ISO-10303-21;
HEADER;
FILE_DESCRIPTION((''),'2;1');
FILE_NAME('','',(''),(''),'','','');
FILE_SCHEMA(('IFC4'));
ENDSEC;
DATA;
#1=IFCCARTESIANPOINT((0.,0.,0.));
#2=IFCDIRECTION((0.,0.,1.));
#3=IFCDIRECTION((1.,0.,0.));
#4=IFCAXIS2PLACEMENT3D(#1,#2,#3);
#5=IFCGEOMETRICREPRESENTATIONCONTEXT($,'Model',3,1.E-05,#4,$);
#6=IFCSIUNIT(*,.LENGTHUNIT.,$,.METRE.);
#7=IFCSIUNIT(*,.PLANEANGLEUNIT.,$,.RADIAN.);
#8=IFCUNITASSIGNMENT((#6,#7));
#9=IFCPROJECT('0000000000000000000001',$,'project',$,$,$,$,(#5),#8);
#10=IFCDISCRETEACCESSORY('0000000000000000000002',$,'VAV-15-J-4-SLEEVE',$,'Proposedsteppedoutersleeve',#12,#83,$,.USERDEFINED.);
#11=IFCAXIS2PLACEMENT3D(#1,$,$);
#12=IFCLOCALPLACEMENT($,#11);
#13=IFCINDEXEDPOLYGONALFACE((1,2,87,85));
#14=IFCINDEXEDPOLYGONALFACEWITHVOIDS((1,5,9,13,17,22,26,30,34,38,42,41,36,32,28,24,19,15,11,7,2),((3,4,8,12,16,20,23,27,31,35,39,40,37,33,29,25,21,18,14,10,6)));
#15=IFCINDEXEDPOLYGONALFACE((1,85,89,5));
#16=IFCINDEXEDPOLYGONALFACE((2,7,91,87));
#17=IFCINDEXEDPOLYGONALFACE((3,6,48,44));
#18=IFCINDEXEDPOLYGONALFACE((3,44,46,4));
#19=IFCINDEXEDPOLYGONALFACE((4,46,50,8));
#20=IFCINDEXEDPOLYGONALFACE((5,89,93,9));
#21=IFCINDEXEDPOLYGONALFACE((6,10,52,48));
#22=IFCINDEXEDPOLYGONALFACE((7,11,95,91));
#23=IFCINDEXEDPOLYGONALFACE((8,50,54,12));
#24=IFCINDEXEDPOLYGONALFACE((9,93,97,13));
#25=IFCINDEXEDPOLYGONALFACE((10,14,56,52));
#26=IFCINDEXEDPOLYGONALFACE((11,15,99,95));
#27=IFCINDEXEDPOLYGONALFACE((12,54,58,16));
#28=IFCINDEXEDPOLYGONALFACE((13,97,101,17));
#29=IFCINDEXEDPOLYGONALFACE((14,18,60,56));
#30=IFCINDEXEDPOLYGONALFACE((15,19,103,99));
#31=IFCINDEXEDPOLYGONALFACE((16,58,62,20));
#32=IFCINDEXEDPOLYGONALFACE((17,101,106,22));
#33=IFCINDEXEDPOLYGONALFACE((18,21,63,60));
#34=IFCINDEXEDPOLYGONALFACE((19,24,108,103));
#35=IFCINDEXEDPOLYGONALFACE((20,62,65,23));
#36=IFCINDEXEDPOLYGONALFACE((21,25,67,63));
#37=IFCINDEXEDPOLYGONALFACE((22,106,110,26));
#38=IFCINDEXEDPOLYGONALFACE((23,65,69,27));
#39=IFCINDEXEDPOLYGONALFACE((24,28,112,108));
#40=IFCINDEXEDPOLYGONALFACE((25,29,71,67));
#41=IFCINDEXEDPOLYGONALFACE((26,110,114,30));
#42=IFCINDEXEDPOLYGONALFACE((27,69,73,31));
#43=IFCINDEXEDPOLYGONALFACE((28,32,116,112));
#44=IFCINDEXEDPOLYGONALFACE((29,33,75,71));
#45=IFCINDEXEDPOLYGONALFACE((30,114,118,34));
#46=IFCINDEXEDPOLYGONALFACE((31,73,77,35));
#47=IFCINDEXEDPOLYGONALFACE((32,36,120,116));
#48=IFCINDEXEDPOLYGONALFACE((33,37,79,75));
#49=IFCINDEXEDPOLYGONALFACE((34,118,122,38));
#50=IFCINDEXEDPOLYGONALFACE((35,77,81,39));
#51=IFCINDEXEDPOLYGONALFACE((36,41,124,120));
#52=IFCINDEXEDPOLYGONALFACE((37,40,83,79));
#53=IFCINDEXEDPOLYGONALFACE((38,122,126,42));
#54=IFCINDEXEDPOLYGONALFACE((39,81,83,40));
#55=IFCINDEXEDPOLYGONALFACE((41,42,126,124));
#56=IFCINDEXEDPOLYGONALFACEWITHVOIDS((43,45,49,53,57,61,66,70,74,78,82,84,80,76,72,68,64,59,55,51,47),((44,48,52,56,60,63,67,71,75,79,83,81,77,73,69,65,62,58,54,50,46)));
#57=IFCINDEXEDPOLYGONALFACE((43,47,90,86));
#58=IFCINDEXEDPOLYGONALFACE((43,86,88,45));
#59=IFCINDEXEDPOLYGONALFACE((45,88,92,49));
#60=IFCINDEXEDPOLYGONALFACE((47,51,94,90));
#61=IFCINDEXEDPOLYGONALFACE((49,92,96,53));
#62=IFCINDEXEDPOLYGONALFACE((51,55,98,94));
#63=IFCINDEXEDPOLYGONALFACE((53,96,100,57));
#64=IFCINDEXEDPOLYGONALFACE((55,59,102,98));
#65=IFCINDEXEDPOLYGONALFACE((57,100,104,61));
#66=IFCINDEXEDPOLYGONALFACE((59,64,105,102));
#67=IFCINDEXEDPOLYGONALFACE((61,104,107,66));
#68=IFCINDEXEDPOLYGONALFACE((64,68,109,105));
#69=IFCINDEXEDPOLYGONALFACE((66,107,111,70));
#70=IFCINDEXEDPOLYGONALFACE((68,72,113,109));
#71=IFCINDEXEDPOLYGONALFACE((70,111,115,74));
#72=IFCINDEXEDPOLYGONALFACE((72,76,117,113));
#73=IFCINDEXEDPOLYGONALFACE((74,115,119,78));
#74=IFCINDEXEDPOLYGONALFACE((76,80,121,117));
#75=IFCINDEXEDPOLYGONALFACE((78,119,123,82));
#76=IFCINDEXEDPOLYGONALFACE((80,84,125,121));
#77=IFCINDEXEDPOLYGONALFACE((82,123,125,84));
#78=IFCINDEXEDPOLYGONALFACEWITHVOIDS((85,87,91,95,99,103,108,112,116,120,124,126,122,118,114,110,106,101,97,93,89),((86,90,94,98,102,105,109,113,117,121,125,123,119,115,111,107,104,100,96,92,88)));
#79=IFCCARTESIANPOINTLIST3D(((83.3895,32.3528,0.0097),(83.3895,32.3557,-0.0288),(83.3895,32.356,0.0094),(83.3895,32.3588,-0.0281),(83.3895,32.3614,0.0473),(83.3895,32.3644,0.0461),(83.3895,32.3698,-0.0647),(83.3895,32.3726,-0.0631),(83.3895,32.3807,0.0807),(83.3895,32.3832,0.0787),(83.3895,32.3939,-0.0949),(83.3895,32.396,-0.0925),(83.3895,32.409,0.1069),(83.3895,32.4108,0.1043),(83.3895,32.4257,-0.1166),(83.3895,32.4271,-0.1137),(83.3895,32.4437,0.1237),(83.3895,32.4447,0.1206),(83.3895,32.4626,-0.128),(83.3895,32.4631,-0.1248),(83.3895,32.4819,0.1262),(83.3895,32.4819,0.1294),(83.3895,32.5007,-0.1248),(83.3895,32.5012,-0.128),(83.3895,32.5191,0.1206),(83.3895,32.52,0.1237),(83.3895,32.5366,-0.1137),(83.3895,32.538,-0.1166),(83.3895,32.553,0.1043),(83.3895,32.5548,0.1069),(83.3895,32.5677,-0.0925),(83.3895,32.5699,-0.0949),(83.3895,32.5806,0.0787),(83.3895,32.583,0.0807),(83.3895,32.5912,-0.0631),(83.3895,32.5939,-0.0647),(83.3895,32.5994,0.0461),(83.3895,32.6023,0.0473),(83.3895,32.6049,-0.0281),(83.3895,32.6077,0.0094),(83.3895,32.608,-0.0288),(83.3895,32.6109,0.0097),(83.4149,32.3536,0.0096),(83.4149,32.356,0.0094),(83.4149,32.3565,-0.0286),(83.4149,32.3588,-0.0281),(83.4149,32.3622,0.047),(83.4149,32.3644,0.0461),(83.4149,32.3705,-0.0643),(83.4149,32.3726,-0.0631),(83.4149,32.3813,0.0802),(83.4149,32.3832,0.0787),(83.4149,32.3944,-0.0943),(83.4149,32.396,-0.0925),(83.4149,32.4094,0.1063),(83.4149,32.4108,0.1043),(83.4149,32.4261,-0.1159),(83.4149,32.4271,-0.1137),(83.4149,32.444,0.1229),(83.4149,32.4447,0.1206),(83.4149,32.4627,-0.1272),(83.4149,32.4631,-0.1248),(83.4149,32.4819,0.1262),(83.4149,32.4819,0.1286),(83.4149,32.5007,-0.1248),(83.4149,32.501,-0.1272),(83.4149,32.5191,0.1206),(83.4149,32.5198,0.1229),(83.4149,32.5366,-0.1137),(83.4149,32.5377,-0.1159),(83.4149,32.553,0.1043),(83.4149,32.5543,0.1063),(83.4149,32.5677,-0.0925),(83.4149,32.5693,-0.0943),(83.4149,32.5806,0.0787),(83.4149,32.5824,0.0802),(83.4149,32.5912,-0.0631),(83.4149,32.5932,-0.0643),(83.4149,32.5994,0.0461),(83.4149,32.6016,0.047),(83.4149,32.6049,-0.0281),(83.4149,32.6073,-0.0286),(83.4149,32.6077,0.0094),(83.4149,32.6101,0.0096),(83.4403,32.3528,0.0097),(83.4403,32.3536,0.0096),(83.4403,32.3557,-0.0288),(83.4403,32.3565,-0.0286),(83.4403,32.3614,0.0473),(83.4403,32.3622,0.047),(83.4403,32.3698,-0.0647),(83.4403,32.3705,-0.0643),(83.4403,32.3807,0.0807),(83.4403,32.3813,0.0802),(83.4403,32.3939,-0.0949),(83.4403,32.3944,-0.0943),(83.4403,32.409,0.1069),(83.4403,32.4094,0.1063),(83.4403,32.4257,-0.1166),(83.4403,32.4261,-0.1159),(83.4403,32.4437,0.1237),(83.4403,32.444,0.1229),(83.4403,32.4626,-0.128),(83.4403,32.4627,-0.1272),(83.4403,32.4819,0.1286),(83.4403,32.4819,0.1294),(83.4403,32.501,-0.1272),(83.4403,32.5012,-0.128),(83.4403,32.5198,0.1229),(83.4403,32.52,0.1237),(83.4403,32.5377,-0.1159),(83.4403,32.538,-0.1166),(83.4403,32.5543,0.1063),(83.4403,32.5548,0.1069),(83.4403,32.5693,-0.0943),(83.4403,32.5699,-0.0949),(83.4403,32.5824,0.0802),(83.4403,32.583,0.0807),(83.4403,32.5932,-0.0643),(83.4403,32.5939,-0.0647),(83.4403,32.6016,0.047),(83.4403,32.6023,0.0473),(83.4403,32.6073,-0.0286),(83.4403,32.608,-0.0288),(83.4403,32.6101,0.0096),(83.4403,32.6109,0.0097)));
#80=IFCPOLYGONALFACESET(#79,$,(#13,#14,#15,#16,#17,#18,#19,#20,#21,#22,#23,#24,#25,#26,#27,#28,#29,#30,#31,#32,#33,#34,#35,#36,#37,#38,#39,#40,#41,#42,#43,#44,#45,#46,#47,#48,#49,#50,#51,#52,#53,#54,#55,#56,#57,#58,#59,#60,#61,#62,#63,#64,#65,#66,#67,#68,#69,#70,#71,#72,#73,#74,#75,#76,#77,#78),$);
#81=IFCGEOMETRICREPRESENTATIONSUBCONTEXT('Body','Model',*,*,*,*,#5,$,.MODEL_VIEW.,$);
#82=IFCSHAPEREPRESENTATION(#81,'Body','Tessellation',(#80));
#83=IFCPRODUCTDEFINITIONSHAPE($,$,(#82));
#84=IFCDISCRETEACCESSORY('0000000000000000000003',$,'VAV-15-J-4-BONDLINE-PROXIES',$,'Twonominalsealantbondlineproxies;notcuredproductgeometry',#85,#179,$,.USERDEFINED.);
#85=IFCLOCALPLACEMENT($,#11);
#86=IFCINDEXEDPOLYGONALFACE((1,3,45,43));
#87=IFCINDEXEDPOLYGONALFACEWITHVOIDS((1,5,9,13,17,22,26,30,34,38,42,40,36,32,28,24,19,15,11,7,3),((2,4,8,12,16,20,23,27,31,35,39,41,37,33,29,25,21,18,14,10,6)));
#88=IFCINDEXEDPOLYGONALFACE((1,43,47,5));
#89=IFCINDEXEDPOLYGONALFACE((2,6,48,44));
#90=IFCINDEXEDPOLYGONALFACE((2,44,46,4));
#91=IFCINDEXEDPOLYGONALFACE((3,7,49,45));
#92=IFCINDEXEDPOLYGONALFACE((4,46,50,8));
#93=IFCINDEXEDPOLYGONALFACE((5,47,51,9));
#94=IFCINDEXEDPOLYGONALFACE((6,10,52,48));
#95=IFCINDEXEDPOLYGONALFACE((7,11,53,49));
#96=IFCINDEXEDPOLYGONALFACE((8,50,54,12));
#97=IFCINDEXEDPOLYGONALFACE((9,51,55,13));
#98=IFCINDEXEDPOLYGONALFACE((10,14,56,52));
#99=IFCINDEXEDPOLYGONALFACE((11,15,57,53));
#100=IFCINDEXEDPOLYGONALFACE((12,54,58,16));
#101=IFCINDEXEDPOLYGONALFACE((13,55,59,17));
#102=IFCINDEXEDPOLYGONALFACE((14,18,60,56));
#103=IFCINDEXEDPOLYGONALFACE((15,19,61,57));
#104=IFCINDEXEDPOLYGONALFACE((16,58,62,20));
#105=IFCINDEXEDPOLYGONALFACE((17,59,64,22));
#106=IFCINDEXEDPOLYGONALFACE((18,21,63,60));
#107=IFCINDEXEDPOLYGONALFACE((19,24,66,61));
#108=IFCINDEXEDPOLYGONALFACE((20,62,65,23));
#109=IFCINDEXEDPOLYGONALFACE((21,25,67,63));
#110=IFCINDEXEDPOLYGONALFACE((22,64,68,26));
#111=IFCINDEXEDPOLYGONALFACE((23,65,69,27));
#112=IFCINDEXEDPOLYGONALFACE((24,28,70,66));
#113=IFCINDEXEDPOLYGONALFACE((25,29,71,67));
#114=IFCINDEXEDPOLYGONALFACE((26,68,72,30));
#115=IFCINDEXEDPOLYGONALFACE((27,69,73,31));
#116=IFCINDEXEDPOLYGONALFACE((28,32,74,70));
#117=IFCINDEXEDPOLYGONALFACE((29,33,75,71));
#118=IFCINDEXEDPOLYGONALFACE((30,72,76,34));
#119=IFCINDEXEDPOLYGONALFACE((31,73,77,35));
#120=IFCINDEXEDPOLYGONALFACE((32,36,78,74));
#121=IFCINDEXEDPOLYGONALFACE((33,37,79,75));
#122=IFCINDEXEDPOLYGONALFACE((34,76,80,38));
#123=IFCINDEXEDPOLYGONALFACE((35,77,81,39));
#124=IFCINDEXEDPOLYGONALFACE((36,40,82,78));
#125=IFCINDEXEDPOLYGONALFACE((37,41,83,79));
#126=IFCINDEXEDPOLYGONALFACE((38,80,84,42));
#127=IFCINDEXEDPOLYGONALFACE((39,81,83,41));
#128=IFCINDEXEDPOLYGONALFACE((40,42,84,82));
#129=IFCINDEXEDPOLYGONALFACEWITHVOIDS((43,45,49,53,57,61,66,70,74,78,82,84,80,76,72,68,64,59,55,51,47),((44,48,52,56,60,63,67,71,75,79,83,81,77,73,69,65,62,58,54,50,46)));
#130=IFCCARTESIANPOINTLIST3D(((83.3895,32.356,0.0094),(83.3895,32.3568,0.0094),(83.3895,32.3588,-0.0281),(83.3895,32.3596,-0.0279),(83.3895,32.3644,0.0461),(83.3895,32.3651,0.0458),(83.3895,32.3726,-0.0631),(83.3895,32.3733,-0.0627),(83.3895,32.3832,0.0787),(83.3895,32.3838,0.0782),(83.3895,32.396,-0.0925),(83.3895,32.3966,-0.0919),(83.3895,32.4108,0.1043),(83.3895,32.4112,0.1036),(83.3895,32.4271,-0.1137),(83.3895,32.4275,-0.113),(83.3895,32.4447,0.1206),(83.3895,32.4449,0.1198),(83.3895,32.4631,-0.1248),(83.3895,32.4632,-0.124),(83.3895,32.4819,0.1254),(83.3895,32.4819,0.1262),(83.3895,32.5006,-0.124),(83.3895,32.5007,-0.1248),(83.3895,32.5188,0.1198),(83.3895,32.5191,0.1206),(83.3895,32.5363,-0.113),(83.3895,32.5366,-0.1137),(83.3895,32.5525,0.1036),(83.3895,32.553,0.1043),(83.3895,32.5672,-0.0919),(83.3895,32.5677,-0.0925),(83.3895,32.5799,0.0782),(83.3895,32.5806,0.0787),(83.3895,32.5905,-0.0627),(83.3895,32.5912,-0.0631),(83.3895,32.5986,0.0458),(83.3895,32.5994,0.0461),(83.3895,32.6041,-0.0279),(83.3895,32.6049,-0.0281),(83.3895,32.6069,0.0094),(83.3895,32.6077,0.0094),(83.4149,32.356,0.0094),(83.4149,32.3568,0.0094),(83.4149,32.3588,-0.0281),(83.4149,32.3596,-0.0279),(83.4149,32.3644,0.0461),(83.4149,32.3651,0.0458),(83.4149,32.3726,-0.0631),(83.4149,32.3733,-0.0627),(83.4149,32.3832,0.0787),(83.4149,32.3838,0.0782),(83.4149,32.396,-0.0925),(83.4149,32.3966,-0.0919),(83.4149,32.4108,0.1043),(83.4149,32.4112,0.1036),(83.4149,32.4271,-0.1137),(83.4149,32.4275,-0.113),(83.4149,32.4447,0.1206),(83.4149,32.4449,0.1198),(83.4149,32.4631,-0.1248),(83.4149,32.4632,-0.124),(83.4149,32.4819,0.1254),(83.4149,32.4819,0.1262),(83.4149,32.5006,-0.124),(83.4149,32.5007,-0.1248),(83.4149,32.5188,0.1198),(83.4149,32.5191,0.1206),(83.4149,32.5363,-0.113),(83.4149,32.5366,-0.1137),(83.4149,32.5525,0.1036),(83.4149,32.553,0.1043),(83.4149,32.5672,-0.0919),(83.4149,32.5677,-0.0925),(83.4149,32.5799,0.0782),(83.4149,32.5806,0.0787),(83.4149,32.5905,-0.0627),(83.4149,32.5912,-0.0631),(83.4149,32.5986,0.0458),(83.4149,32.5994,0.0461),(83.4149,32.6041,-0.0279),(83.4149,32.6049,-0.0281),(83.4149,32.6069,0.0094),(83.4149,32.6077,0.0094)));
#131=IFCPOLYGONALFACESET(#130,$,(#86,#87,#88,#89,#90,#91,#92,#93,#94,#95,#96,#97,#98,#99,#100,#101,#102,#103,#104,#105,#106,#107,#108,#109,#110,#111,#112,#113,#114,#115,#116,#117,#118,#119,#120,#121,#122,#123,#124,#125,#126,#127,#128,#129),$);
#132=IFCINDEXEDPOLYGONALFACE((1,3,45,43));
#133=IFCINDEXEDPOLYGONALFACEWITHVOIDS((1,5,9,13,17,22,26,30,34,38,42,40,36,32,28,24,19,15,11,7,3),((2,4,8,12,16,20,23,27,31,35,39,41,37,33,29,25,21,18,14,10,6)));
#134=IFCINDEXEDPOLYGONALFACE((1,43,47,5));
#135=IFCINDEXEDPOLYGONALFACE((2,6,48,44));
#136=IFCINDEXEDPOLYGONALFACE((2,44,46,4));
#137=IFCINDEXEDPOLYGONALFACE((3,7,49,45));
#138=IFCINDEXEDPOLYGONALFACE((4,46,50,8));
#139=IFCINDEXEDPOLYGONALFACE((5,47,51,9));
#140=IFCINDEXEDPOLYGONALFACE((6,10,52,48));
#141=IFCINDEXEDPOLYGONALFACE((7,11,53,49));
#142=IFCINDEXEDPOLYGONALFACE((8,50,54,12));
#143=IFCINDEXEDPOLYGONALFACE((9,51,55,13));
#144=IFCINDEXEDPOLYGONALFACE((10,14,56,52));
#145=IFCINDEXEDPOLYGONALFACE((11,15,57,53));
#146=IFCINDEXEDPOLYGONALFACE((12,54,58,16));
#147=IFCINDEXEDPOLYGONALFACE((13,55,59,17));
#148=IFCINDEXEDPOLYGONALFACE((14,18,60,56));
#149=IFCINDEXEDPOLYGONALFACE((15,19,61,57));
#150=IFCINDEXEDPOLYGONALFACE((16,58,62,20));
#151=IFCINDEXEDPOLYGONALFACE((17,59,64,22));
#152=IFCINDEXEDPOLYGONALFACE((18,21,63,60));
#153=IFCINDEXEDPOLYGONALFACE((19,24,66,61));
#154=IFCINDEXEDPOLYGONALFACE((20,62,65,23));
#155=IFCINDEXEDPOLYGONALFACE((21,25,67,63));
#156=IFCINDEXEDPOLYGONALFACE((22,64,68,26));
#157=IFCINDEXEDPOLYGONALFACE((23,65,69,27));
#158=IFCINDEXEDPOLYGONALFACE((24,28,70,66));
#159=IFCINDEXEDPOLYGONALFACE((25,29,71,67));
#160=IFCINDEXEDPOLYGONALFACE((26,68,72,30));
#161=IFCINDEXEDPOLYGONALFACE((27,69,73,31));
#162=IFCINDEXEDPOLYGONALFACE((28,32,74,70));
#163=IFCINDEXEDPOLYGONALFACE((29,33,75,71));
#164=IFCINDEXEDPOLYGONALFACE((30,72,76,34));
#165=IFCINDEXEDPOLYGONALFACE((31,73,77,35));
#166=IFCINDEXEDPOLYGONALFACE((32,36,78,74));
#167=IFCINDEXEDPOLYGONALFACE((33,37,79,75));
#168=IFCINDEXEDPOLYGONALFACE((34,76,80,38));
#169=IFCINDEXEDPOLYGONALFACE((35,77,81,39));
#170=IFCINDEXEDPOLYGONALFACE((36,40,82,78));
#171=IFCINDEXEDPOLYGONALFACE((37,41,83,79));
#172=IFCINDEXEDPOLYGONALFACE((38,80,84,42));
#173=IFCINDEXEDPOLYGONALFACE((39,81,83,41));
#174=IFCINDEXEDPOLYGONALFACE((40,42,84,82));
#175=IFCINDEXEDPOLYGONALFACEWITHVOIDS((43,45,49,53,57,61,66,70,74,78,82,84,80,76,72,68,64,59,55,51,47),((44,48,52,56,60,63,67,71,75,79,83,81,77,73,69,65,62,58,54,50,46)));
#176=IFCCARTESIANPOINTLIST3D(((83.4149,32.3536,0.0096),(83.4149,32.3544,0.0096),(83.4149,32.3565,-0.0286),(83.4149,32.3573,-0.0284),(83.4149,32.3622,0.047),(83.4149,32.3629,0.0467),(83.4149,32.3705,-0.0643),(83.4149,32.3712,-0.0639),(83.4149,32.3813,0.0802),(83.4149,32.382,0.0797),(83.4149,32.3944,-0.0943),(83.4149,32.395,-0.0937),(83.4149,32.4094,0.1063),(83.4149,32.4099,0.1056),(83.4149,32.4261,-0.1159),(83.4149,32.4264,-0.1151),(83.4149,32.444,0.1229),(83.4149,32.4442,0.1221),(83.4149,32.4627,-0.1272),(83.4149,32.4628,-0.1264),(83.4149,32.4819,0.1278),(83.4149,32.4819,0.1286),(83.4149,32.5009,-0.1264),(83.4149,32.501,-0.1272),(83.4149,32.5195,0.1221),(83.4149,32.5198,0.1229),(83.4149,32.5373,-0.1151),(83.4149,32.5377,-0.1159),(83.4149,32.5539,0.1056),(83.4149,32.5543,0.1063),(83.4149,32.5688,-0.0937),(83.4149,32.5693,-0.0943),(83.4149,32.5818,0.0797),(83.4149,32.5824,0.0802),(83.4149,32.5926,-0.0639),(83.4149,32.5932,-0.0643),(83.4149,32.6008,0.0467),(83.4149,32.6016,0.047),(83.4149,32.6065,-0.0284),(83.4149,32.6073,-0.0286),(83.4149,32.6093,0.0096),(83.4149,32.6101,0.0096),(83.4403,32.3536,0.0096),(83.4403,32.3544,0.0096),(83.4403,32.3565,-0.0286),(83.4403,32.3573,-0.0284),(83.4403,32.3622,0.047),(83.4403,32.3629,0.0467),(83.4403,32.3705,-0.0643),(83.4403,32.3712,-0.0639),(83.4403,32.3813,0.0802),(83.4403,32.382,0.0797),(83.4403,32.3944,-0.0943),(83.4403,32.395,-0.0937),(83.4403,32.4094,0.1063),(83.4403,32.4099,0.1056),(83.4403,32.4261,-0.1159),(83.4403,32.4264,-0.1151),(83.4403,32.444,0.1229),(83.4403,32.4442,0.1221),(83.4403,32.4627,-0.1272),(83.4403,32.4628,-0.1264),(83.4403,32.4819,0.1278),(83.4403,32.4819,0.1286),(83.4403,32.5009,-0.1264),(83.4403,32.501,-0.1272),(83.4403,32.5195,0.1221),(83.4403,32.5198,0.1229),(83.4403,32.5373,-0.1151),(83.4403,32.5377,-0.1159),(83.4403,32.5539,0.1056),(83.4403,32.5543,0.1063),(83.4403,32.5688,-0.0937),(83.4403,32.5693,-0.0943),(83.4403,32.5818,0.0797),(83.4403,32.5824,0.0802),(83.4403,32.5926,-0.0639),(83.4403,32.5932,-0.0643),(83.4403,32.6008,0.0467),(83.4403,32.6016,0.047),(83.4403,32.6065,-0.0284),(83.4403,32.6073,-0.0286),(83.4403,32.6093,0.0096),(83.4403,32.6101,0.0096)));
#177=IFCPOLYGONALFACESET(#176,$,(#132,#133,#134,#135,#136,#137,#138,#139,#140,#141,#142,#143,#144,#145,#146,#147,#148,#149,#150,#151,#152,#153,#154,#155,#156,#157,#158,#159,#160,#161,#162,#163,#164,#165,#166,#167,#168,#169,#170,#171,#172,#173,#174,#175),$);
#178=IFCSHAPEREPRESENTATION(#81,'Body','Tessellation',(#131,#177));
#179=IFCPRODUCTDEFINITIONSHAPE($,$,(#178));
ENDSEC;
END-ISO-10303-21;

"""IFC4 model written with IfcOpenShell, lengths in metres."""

from ifc_helpers import new_model, entity, si_unit, frame, origin_with_axes, place, context, subcontext, project, element, save


model = new_model("IFC4")

# Units and contexts
model_context = context("Model", 3, precision=1e-05, world=origin_with_axes())
body_context = subcontext(model_context, "Body", "Model", "MODEL_VIEW")
ifc_project = project(units=[si_unit("LENGTHUNIT", "METRE"), si_unit("PLANEANGLEUNIT", "RADIAN")], contexts=[model_context])

# Discrete accessories
discrete_accessory_1_placement = place(None, frame((83.4149, 32.4819, 0.0), z_axis=(0.0, 1.0, 0.0), x_axis=(0.0, 0.0, 1.0)))
element("IfcDiscreteAccessory", 1, at=discrete_accessory_1_placement, Name="VAV-15-J-4-SLEEVE", ObjectType="Proposedsteppedoutersleeve", PredefinedType="USERDEFINED", context=body_context, shape_type="SweptSolid", body=[
    entity("IfcRevolvedAreaSolid", entity("IfcArbitraryClosedProfileDef", "AREA", None, entity("IfcPolyline", [entity("IfcCartesianPoint", [0.1262, -0.0254]), entity("IfcCartesianPoint", [0.1294, -0.0254]), entity("IfcCartesianPoint", [0.1294, 0.0254]), entity("IfcCartesianPoint", [0.1286, 0.0254]), entity("IfcCartesianPoint", [0.1286, 0.0]), entity("IfcCartesianPoint", [0.1262, 0.0]), entity("IfcCartesianPoint", [0.1262, -0.0254])])), entity("IfcAxis2Placement3D", entity("IfcCartesianPoint", [0.0, 0.0, 0.0])), entity("IfcAxis1Placement", entity("IfcCartesianPoint", [0.0, 0.0, 0.0]), entity("IfcDirection", [0.0, 1.0, 0.0])), 6.283185),
])
discrete_accessory_2_placement = place(None, frame((83.4149, 32.4819, 0.0), z_axis=(0.0, 1.0, 0.0), x_axis=(0.0, 0.0, 1.0)))
element("IfcDiscreteAccessory", 2, at=discrete_accessory_2_placement, Name="VAV-15-J-4-BONDLINE-PROXIES", ObjectType="Twonominalsealantbondlineproxies;notcuredproductgeometry", PredefinedType="USERDEFINED", context=body_context, shape_type="SweptSolid", body=[
    entity("IfcRevolvedAreaSolid", entity("IfcArbitraryClosedProfileDef", "AREA", None, entity("IfcPolyline", [entity("IfcCartesianPoint", [0.1254, -0.0254]), entity("IfcCartesianPoint", [0.1262, -0.0254]), entity("IfcCartesianPoint", [0.1262, 0.0]), entity("IfcCartesianPoint", [0.1254, 0.0]), entity("IfcCartesianPoint", [0.1254, -0.0254])])), entity("IfcAxis2Placement3D", entity("IfcCartesianPoint", [0.0, 0.0, 0.0])), entity("IfcAxis1Placement", entity("IfcCartesianPoint", [0.0, 0.0, 0.0]), entity("IfcDirection", [0.0, 1.0, 0.0])), 6.283185),
    entity("IfcRevolvedAreaSolid", entity("IfcArbitraryClosedProfileDef", "AREA", None, entity("IfcPolyline", [entity("IfcCartesianPoint", [0.1278, 0.0]), entity("IfcCartesianPoint", [0.1286, 0.0]), entity("IfcCartesianPoint", [0.1286, 0.0254]), entity("IfcCartesianPoint", [0.1278, 0.0254]), entity("IfcCartesianPoint", [0.1278, 0.0])])), entity("IfcAxis2Placement3D", entity("IfcCartesianPoint", [0.0, 0.0, 0.0])), entity("IfcAxis1Placement", entity("IfcCartesianPoint", [0.0, 0.0, 0.0]), entity("IfcDirection", [0.0, 1.0, 0.0])), 6.283185),
])

save(model, "model.ifc")
